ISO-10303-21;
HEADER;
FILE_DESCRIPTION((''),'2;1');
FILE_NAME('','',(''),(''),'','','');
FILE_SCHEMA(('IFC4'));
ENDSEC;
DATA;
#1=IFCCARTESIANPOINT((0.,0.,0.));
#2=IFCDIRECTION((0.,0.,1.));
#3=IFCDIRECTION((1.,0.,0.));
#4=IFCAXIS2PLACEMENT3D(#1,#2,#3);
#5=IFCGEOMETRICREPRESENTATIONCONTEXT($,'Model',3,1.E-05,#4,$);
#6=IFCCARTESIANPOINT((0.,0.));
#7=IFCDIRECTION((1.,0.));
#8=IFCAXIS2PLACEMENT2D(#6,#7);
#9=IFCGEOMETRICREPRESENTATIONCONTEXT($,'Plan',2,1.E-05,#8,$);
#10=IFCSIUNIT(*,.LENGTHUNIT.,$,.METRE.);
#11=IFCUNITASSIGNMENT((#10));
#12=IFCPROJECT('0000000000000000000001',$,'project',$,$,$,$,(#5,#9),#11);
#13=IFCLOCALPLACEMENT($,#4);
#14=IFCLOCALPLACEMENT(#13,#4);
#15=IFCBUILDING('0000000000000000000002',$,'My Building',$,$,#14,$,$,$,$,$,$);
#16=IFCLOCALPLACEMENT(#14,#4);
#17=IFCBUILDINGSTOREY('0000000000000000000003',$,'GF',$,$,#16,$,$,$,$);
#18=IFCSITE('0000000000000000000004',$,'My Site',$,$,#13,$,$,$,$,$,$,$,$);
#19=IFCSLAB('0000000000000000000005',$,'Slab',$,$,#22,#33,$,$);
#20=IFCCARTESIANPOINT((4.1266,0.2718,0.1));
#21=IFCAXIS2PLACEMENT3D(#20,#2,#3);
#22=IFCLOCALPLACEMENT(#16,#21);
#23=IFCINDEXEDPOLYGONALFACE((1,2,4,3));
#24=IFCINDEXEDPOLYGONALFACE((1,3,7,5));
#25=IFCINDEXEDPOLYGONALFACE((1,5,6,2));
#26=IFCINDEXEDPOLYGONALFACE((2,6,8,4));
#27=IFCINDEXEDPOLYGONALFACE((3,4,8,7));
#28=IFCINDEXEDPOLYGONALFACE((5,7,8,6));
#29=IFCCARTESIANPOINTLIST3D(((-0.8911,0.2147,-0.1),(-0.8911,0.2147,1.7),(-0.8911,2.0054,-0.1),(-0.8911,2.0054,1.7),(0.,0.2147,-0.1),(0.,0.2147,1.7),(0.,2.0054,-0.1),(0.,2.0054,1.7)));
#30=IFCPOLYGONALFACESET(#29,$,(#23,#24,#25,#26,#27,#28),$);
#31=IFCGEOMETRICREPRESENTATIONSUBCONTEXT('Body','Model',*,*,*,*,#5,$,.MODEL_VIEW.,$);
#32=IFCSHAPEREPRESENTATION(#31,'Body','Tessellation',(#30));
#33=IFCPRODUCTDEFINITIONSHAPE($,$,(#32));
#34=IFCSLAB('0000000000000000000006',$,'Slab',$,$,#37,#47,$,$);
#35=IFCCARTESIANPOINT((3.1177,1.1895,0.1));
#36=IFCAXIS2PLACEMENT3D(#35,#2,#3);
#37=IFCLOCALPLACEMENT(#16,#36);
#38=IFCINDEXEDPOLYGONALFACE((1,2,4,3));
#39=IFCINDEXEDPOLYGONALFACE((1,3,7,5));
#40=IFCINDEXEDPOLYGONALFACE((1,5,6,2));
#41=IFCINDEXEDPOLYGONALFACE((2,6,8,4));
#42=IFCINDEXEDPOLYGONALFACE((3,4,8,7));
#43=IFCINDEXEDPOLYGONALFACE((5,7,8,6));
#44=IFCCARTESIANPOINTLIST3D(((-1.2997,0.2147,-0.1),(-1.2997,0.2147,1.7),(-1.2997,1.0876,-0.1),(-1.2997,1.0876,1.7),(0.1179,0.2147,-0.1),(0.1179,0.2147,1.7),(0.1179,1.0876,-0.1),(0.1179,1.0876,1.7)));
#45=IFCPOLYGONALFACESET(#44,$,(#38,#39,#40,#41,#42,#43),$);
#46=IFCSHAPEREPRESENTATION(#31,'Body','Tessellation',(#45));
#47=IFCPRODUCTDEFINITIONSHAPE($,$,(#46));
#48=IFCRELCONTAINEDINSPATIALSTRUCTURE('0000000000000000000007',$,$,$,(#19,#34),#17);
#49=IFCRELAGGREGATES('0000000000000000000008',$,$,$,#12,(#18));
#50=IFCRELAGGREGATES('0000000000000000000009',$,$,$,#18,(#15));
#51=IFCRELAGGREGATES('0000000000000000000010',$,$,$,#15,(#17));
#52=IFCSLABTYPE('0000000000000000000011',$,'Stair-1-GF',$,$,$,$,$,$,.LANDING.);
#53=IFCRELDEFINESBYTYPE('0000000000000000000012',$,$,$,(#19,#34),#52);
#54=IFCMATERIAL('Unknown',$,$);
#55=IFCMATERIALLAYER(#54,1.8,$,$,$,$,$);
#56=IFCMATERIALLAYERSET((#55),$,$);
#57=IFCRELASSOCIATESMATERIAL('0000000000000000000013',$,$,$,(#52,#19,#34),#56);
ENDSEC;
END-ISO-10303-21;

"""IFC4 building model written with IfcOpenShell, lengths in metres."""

from ifc_helpers import new_model, si_unit, frame, origin_with_axes, origin_2d_with_axis, place, context, subcontext, project, spatial, indexed_curve, outline, extrude, material, layer, layer_set, layer_usage, type_object, element, save


model = new_model("IFC4")

# Units and contexts
model_context = context("Model", 3, precision=1e-05, world=origin_with_axes())
plan_context = context("Plan", 2, precision=1e-05, world=origin_2d_with_axis())
body_context_1 = subcontext(model_context, "Body", "Model", "MODEL_VIEW")
ifc_project = project(units=[si_unit("LENGTHUNIT", "METRE")], contexts=[model_context, plan_context])

# Site, building, storey
site_placement = place(None, origin_with_axes())
site = spatial("IfcSite", under=ifc_project, at=site_placement, Name="My Site")
building_placement = place(site_placement, origin_with_axes())
building = spatial("IfcBuilding", under=site, at=building_placement, Name="My Building")
storey_placement = place(building_placement, origin_with_axes())
storey = spatial("IfcBuildingStorey", under=building, at=storey_placement, Name="GF")

# Shared definitions
ifc_material = material(Name="Unknown")

# Slabs
ifc_layer_1 = layer(ifc_material, 1.8)
ifc_layer_set_1 = layer_set([ifc_layer_1])
ifc_layer_usage_1 = layer_usage(ifc_layer_set_1, "AXIS3", "POSITIVE", -0.1)
slab_type_1 = type_object("IfcSlabType", Name="Stair-1-GF", PredefinedType="LANDING", material=ifc_layer_set_1)
slab_1_placement = place(storey_placement, frame((4.1266, 0.2718, 0.1), z_axis=(0.0, 0.0, 1.0), x_axis=(1.0, 0.0, 0.0)))
element("IfcSlab", 1, at=slab_1_placement, inside=storey, type_object=slab_type_1, material=ifc_layer_usage_1, Name="Slab", context=body_context_1, shape_type="SweptSolid", body=[
    extrude(outline(indexed_curve([(-0.8911, 0.2147), (-0.8911, 2.0054), (0.0, 2.0054), (0.0, 0.2147), (-0.8911, 0.2147)])), frame((0.0, 0.0, -0.1), z_axis=(0.0, 0.0, 1.0), x_axis=(1.0, 0.0, 0.0)), (0.0, 0.0, 1.0), 1.8),
])
ifc_layer_usage_2 = layer_usage(ifc_layer_set_1, "AXIS3", "POSITIVE", -0.1)
slab_2_placement = place(storey_placement, frame((3.1177, 1.1895, 0.1), z_axis=(0.0, 0.0, 1.0), x_axis=(1.0, 0.0, 0.0)))
element("IfcSlab", 2, at=slab_2_placement, inside=storey, type_object=slab_type_1, material=ifc_layer_usage_2, Name="Slab", context=body_context_1, shape_type="SweptSolid", body=[
    extrude(outline(indexed_curve([(0.1179, 0.2147), (0.1179, 1.0876), (-1.2997, 1.0876), (-1.2997, 0.2147), (0.1179, 0.2147)])), frame((0.0, 0.0, -0.1), z_axis=(0.0, 0.0, 1.0), x_axis=(1.0, 0.0, 0.0)), (0.0, 0.0, 1.0), 1.8),
])

save(model, "model.ifc")
